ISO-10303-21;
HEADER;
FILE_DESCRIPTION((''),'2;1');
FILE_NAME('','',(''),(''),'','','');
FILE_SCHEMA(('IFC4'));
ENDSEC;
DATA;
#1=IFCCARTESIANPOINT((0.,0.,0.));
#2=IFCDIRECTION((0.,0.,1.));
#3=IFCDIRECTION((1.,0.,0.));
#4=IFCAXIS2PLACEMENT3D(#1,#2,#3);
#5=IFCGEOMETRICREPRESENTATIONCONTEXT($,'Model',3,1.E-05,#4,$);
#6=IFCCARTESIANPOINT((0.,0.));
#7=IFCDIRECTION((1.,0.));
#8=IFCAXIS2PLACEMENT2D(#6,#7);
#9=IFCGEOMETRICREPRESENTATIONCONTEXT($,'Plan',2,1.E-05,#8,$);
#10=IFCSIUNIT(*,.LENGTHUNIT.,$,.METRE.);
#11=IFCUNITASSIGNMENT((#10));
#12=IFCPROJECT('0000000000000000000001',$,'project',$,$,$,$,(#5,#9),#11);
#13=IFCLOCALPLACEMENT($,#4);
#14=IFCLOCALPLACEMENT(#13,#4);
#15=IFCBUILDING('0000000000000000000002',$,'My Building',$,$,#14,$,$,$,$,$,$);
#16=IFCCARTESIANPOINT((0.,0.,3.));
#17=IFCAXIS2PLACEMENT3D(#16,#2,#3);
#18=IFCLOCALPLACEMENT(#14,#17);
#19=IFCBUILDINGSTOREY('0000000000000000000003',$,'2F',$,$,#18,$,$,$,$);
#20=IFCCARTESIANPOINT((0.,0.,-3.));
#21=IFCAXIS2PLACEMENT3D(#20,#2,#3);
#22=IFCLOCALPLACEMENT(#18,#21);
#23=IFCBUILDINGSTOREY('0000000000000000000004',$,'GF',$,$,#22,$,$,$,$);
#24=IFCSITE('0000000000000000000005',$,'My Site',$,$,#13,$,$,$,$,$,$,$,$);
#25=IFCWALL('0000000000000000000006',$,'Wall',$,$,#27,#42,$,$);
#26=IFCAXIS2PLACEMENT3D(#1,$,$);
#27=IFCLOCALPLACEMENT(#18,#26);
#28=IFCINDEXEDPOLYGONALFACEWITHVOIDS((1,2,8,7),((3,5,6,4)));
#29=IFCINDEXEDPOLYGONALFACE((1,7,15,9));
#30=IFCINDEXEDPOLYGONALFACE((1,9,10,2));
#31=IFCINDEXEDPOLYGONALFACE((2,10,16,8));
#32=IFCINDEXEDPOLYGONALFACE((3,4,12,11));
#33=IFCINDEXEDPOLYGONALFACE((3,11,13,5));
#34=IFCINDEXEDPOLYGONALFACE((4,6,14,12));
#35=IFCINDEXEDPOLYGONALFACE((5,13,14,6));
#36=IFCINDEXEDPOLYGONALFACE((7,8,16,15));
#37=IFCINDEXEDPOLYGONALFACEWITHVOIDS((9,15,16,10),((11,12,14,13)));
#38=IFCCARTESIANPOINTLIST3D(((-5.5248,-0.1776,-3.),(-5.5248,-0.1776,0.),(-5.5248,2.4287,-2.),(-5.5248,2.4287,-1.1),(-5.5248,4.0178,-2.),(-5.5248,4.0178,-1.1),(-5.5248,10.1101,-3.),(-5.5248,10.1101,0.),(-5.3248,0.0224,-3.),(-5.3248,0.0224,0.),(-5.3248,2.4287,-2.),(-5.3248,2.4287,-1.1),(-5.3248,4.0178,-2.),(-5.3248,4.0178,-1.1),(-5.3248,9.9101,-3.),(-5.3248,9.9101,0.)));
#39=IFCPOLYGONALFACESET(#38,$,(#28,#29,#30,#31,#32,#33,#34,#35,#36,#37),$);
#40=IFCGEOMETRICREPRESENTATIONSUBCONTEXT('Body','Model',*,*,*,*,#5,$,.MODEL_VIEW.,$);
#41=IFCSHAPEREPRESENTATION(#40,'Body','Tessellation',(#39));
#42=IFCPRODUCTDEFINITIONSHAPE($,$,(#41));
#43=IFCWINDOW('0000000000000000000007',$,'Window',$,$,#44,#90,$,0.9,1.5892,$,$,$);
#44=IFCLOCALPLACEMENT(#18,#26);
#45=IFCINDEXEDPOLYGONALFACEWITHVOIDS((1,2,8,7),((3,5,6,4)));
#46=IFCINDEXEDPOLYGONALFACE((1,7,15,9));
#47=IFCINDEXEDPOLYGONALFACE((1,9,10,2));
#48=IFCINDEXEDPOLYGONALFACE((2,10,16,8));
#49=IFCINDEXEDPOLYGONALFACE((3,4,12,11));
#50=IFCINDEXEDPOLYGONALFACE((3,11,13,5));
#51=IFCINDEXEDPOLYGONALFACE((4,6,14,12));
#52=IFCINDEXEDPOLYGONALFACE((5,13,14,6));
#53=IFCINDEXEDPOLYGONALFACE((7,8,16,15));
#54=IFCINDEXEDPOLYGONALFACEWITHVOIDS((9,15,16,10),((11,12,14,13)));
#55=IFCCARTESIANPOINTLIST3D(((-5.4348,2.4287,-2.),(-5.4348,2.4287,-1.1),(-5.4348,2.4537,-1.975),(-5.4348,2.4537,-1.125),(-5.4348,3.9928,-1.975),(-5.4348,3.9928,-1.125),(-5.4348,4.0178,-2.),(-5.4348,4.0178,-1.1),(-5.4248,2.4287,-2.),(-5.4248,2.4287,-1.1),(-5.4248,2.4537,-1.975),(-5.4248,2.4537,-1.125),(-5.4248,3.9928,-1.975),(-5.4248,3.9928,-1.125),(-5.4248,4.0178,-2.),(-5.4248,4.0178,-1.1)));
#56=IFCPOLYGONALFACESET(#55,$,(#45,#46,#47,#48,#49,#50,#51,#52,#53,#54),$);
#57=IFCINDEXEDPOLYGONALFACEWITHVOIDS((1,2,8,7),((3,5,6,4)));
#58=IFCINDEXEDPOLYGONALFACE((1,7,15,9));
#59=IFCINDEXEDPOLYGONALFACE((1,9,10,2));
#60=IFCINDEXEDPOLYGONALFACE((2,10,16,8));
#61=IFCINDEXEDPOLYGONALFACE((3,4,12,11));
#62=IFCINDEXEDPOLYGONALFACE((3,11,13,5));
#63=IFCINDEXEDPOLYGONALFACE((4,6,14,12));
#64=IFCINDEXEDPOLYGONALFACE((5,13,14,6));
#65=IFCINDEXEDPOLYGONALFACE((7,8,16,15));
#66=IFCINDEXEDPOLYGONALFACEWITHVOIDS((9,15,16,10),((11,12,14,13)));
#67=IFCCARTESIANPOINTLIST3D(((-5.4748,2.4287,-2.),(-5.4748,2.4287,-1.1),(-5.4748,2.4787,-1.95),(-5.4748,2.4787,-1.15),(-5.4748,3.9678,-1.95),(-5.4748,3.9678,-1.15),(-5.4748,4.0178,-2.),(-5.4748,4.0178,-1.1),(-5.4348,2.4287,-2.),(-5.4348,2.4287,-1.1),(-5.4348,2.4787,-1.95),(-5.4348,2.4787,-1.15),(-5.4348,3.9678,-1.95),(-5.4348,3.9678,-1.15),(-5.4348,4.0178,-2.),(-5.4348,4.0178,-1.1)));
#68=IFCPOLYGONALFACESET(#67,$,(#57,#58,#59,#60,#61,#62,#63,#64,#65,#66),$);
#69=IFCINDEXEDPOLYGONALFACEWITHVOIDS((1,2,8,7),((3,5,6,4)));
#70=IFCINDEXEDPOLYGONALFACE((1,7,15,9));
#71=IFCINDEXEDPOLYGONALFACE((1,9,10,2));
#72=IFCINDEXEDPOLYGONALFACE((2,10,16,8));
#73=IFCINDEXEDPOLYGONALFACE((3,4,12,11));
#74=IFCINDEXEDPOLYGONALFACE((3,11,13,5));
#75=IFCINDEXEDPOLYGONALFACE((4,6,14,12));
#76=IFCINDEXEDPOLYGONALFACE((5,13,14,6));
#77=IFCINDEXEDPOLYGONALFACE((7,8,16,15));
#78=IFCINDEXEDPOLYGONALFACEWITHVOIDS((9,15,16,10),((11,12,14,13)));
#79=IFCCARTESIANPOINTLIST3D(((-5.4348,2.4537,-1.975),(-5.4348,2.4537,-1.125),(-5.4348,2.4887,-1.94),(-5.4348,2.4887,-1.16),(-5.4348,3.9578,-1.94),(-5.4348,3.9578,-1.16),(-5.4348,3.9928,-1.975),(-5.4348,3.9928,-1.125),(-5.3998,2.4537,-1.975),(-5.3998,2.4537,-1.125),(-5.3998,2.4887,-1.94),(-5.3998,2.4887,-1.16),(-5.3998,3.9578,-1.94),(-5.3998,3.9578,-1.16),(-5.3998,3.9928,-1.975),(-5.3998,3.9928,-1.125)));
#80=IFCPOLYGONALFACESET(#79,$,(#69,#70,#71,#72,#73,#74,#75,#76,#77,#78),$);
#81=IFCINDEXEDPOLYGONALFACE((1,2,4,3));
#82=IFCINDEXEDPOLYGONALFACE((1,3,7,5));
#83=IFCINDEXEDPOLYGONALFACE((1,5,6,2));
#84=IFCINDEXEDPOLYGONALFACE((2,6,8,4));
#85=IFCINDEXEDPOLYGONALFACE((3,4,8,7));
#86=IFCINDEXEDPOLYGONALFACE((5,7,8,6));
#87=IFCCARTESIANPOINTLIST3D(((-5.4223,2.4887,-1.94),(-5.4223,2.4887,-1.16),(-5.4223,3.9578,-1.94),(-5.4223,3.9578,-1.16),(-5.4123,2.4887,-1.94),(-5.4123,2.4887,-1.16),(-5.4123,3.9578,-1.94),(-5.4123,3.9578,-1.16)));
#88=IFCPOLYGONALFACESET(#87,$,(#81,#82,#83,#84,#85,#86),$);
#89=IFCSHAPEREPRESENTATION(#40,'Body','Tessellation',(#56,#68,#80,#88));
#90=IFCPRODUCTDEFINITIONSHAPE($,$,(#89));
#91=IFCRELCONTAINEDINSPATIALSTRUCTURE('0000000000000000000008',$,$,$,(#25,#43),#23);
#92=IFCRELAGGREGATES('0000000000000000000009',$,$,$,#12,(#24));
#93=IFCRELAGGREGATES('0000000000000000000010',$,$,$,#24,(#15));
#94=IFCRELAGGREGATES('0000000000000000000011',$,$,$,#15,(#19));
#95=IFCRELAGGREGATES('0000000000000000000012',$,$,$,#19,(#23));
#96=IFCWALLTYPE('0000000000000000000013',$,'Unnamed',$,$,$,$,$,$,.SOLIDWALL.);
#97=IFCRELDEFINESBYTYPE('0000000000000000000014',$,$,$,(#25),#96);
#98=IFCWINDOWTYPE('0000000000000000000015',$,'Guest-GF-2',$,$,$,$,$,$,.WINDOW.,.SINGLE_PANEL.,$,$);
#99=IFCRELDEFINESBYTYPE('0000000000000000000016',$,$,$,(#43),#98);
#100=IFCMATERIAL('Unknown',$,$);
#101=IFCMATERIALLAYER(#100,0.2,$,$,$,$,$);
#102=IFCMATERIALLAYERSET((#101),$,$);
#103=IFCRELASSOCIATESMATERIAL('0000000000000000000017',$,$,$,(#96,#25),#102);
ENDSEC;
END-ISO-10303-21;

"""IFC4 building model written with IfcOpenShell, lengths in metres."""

from ifc_helpers import new_model, entity, si_unit, frame, origin_with_axes, origin_2d_with_axis, place, context, subcontext, project, spatial, line, indexed_curve, outline, extrude, shape, source, transform, mapped, material, layer, layer_set, layer_usage, type_object, type_shapes, element, fill, save


model = new_model("IFC4")

# Units and contexts
model_context = context("Model", 3, precision=1e-05, world=origin_with_axes())
plan_context = context("Plan", 2, precision=1e-05, world=origin_2d_with_axis())
body_context_1 = subcontext(model_context, "Body", "Model", "MODEL_VIEW")
body_context_2 = subcontext(plan_context, "Body", "Plan", "PLAN_VIEW")
ifc_project = project(units=[si_unit("LENGTHUNIT", "METRE")], contexts=[model_context, plan_context])

# Site, building, storeys
site_placement = place(None, origin_with_axes())
site = spatial("IfcSite", under=ifc_project, at=site_placement, Name="My Site")
building_placement = place(site_placement, origin_with_axes())
building = spatial("IfcBuilding", under=site, at=building_placement, Name="My Building")
storey_1_placement = place(building_placement, frame((0.0, 0.0, 3.0), z_axis=(0.0, 0.0, 1.0), x_axis=(1.0, 0.0, 0.0)))
storey_1 = spatial("IfcBuildingStorey", under=building, at=storey_1_placement, Name="2F")
storey_2_placement = place(storey_1_placement, frame((0.0, 0.0, -3.0), z_axis=(0.0, 0.0, 1.0), x_axis=(1.0, 0.0, 0.0)))
storey_2 = spatial("IfcBuildingStorey", under=storey_1, at=storey_2_placement, Name="GF")

# Shared definitions
ifc_material = material(Name="Unknown")

# Shared definitions
ifc_layer_1 = layer(ifc_material, 0.2)
ifc_layer_set_1 = layer_set([ifc_layer_1])
wall_type = type_object("IfcWallType", Name="Unnamed", PredefinedType="SOLIDWALL", material=ifc_layer_set_1)

# Wall, opening, window
ifc_layer_usage_1 = layer_usage(ifc_layer_set_1, "AXIS2", "POSITIVE", 0.0)
wall_1_placement = place(storey_2_placement, frame((-5.5248, 10.1101, 0.0), z_axis=(0.0, 0.0, 1.0), x_axis=(0.0, -1.0, 0.0)))
wall_1 = element("IfcWall", 1, at=wall_1_placement, inside=storey_2, type_object=wall_type, material=ifc_layer_usage_1, Name="Wall", context=body_context_1, shape_type="SweptSolid", body=[
    extrude(outline(indexed_curve([(0.0, 0.0), (0.2, 0.2), (10.0877, 0.2), (10.2877, 0.0)], segments=[line(1, 2, 3, 4, 1)])), origin_with_axes(), (0.0, 0.0, 1.0), 3.0),
])
shared_shape_1 = source(origin_with_axes(), body_context_1, "Body", "SweptSolid", [
    extrude(outline(indexed_curve([(0.0, 0.0), (1.5892, 0.0), (1.5892, 0.9), (0.0, 0.9)], segments=[line(1, 2, 3, 4, 1)])), frame((0.0, -0.6, 0.0), z_axis=(0.0, -1.0, 0.0), x_axis=(1.0, 0.0, 0.0)), (0.0, 0.0, -1.0), 1.2),
])
opening_1_placement = place(wall_1_placement, frame((6.0922, 0.0, 1.0), z_axis=(0.0, 0.0, 1.0), x_axis=(1.0, 0.0, 0.0)))
opening_1 = element("IfcOpeningElement", 2, at=opening_1_placement, cuts=wall_1, PredefinedType="OPENING", context=body_context_1, shape_type="MappedRepresentation", body=[
    mapped(shared_shape_1, transform((0.0, 0.0, 0.0), x_axis=(1.0, 0.0, 0.0), y_axis=(0.0, 1.0, 0.0), z_axis=(0.0, 0.0, 1.0), scale=1.0)),
])
window_type_1 = type_object("IfcWindowType", Name="Guest-GF-2", PartitioningType="SINGLE_PANEL", PredefinedType="WINDOW")
shared_shape_2 = source(origin_with_axes(), body_context_1, "Body", "SweptSolid", [
    extrude(outline(indexed_curve([(0.0, 0.0), (1.5892, 0.0), (1.5892, 0.9), (0.0, 0.9)], segments=[line(1, 2, 3, 4, 1)]), holes=[indexed_curve([(0.025, 0.025), (1.5642, 0.025), (1.5642, 0.875), (0.025, 0.875)], segments=[line(1, 2, 3, 4, 1)])]), frame((0.0, 0.09, 0.0), z_axis=(0.0, -1.0, 0.0), x_axis=(1.0, 0.0, 0.0)), (0.0, 0.0, -1.0), 0.01),
    extrude(outline(indexed_curve([(0.0, 0.0), (1.5892, 0.0), (1.5892, 0.9), (0.0, 0.9)], segments=[line(1, 2, 3, 4, 1)]), holes=[indexed_curve([(0.05, 0.05), (1.5392, 0.05), (1.5392, 0.85), (0.05, 0.85)], segments=[line(1, 2, 3, 4, 1)])]), frame((0.0, 0.05, 0.0), z_axis=(0.0, -1.0, 0.0), x_axis=(1.0, 0.0, 0.0)), (0.0, 0.0, -1.0), 0.04),
    extrude(outline(indexed_curve([(0.0, 0.0), (1.5392, 0.0), (1.5392, 0.85), (0.0, 0.85)], segments=[line(1, 2, 3, 4, 1)]), holes=[indexed_curve([(0.035, 0.035), (1.5042, 0.035), (1.5042, 0.815), (0.035, 0.815)], segments=[line(1, 2, 3, 4, 1)])]), frame((0.025, 0.09, 0.025), z_axis=(0.0, -1.0, 0.0), x_axis=(1.0, 0.0, 0.0)), (0.0, 0.0, -1.0), 0.035),
    extrude(outline(indexed_curve([(0.035, 0.035), (1.5042, 0.035), (1.5042, 0.815), (0.035, 0.815)], segments=[line(1, 2, 3, 4, 1)])), frame((0.025, 0.1025, 0.025), z_axis=(0.0, -1.0, 0.0), x_axis=(1.0, 0.0, 0.0)), (0.0, 0.0, -1.0), 0.01),
])
shared_shape_3 = source(origin_with_axes(), body_context_2, "Body", "Curve2D", [
    entity("IfcIndexedPolyCurve", entity("IfcCartesianPointList2D", [[0.05, 0.05], [1.5392, 0.05]])),
    entity("IfcIndexedPolyCurve", entity("IfcCartesianPointList2D", [[0.0, 0.1], [0.025, 0.1], [0.025, 0.09], [0.05, 0.09], [0.05, 0.05], [0.0, 0.05]]), [entity("IfcLineIndex", [1, 2, 3, 4, 5, 6, 1])]),
    entity("IfcIndexedPolyCurve", entity("IfcCartesianPointList2D", [[1.5892, 0.1], [1.5642, 0.1], [1.5642, 0.09], [1.5392, 0.09], [1.5392, 0.05], [1.5892, 0.05]]), [entity("IfcLineIndex", [1, 2, 3, 4, 5, 6, 1])]),
    entity("IfcIndexedPolyCurve", entity("IfcCartesianPointList2D", [[0.025, 0.09], [0.06, 0.09], [0.06, 0.125], [0.025, 0.125]]), [entity("IfcLineIndex", [1, 2, 3, 4, 1])]),
    entity("IfcIndexedPolyCurve", entity("IfcCartesianPointList2D", [[1.5642, 0.09], [1.5292, 0.09], [1.5292, 0.125], [1.5642, 0.125]]), [entity("IfcLineIndex", [1, 2, 3, 4, 1])]),
    entity("IfcIndexedPolyCurve", entity("IfcCartesianPointList2D", [[0.06, 0.09], [1.5292, 0.09]])),
    entity("IfcIndexedPolyCurve", entity("IfcCartesianPointList2D", [[0.06, 0.125], [1.5292, 0.125]])),
    entity("IfcIndexedPolyCurve", entity("IfcCartesianPointList2D", [[0.06, 0.1075], [1.5292, 0.1075]])),
])
type_shapes(window_type_1, [shared_shape_2, shared_shape_3])
window_1_placement = place(opening_1_placement, frame((0.0, 0.0, 0.0), z_axis=(0.0, 0.0, 1.0), x_axis=(1.0, 0.0, 0.0)))
window_1 = element("IfcWindow", 3, at=window_1_placement, inside=storey_2, type_object=window_type_1, Name="Window", OverallHeight=0.9, OverallWidth=1.5892, shapes=[
    shape(body_context_1, "Body", "MappedRepresentation", [mapped(shared_shape_2, transform((0.0, 0.0, 0.0), x_axis=(1.0, 0.0, 0.0), y_axis=(0.0, 1.0, 0.0), z_axis=(0.0, 0.0, 1.0), scale=1.0))]),
    shape(body_context_2, "Body", "MappedRepresentation", [mapped(shared_shape_3, transform((0.0, 0.0, 0.0), x_axis=(1.0, 0.0, 0.0), y_axis=(0.0, 1.0, 0.0), z_axis=(0.0, 0.0, 1.0), scale=1.0))]),
])
fill(opening_1, window_1)

save(model, "model.ifc")
